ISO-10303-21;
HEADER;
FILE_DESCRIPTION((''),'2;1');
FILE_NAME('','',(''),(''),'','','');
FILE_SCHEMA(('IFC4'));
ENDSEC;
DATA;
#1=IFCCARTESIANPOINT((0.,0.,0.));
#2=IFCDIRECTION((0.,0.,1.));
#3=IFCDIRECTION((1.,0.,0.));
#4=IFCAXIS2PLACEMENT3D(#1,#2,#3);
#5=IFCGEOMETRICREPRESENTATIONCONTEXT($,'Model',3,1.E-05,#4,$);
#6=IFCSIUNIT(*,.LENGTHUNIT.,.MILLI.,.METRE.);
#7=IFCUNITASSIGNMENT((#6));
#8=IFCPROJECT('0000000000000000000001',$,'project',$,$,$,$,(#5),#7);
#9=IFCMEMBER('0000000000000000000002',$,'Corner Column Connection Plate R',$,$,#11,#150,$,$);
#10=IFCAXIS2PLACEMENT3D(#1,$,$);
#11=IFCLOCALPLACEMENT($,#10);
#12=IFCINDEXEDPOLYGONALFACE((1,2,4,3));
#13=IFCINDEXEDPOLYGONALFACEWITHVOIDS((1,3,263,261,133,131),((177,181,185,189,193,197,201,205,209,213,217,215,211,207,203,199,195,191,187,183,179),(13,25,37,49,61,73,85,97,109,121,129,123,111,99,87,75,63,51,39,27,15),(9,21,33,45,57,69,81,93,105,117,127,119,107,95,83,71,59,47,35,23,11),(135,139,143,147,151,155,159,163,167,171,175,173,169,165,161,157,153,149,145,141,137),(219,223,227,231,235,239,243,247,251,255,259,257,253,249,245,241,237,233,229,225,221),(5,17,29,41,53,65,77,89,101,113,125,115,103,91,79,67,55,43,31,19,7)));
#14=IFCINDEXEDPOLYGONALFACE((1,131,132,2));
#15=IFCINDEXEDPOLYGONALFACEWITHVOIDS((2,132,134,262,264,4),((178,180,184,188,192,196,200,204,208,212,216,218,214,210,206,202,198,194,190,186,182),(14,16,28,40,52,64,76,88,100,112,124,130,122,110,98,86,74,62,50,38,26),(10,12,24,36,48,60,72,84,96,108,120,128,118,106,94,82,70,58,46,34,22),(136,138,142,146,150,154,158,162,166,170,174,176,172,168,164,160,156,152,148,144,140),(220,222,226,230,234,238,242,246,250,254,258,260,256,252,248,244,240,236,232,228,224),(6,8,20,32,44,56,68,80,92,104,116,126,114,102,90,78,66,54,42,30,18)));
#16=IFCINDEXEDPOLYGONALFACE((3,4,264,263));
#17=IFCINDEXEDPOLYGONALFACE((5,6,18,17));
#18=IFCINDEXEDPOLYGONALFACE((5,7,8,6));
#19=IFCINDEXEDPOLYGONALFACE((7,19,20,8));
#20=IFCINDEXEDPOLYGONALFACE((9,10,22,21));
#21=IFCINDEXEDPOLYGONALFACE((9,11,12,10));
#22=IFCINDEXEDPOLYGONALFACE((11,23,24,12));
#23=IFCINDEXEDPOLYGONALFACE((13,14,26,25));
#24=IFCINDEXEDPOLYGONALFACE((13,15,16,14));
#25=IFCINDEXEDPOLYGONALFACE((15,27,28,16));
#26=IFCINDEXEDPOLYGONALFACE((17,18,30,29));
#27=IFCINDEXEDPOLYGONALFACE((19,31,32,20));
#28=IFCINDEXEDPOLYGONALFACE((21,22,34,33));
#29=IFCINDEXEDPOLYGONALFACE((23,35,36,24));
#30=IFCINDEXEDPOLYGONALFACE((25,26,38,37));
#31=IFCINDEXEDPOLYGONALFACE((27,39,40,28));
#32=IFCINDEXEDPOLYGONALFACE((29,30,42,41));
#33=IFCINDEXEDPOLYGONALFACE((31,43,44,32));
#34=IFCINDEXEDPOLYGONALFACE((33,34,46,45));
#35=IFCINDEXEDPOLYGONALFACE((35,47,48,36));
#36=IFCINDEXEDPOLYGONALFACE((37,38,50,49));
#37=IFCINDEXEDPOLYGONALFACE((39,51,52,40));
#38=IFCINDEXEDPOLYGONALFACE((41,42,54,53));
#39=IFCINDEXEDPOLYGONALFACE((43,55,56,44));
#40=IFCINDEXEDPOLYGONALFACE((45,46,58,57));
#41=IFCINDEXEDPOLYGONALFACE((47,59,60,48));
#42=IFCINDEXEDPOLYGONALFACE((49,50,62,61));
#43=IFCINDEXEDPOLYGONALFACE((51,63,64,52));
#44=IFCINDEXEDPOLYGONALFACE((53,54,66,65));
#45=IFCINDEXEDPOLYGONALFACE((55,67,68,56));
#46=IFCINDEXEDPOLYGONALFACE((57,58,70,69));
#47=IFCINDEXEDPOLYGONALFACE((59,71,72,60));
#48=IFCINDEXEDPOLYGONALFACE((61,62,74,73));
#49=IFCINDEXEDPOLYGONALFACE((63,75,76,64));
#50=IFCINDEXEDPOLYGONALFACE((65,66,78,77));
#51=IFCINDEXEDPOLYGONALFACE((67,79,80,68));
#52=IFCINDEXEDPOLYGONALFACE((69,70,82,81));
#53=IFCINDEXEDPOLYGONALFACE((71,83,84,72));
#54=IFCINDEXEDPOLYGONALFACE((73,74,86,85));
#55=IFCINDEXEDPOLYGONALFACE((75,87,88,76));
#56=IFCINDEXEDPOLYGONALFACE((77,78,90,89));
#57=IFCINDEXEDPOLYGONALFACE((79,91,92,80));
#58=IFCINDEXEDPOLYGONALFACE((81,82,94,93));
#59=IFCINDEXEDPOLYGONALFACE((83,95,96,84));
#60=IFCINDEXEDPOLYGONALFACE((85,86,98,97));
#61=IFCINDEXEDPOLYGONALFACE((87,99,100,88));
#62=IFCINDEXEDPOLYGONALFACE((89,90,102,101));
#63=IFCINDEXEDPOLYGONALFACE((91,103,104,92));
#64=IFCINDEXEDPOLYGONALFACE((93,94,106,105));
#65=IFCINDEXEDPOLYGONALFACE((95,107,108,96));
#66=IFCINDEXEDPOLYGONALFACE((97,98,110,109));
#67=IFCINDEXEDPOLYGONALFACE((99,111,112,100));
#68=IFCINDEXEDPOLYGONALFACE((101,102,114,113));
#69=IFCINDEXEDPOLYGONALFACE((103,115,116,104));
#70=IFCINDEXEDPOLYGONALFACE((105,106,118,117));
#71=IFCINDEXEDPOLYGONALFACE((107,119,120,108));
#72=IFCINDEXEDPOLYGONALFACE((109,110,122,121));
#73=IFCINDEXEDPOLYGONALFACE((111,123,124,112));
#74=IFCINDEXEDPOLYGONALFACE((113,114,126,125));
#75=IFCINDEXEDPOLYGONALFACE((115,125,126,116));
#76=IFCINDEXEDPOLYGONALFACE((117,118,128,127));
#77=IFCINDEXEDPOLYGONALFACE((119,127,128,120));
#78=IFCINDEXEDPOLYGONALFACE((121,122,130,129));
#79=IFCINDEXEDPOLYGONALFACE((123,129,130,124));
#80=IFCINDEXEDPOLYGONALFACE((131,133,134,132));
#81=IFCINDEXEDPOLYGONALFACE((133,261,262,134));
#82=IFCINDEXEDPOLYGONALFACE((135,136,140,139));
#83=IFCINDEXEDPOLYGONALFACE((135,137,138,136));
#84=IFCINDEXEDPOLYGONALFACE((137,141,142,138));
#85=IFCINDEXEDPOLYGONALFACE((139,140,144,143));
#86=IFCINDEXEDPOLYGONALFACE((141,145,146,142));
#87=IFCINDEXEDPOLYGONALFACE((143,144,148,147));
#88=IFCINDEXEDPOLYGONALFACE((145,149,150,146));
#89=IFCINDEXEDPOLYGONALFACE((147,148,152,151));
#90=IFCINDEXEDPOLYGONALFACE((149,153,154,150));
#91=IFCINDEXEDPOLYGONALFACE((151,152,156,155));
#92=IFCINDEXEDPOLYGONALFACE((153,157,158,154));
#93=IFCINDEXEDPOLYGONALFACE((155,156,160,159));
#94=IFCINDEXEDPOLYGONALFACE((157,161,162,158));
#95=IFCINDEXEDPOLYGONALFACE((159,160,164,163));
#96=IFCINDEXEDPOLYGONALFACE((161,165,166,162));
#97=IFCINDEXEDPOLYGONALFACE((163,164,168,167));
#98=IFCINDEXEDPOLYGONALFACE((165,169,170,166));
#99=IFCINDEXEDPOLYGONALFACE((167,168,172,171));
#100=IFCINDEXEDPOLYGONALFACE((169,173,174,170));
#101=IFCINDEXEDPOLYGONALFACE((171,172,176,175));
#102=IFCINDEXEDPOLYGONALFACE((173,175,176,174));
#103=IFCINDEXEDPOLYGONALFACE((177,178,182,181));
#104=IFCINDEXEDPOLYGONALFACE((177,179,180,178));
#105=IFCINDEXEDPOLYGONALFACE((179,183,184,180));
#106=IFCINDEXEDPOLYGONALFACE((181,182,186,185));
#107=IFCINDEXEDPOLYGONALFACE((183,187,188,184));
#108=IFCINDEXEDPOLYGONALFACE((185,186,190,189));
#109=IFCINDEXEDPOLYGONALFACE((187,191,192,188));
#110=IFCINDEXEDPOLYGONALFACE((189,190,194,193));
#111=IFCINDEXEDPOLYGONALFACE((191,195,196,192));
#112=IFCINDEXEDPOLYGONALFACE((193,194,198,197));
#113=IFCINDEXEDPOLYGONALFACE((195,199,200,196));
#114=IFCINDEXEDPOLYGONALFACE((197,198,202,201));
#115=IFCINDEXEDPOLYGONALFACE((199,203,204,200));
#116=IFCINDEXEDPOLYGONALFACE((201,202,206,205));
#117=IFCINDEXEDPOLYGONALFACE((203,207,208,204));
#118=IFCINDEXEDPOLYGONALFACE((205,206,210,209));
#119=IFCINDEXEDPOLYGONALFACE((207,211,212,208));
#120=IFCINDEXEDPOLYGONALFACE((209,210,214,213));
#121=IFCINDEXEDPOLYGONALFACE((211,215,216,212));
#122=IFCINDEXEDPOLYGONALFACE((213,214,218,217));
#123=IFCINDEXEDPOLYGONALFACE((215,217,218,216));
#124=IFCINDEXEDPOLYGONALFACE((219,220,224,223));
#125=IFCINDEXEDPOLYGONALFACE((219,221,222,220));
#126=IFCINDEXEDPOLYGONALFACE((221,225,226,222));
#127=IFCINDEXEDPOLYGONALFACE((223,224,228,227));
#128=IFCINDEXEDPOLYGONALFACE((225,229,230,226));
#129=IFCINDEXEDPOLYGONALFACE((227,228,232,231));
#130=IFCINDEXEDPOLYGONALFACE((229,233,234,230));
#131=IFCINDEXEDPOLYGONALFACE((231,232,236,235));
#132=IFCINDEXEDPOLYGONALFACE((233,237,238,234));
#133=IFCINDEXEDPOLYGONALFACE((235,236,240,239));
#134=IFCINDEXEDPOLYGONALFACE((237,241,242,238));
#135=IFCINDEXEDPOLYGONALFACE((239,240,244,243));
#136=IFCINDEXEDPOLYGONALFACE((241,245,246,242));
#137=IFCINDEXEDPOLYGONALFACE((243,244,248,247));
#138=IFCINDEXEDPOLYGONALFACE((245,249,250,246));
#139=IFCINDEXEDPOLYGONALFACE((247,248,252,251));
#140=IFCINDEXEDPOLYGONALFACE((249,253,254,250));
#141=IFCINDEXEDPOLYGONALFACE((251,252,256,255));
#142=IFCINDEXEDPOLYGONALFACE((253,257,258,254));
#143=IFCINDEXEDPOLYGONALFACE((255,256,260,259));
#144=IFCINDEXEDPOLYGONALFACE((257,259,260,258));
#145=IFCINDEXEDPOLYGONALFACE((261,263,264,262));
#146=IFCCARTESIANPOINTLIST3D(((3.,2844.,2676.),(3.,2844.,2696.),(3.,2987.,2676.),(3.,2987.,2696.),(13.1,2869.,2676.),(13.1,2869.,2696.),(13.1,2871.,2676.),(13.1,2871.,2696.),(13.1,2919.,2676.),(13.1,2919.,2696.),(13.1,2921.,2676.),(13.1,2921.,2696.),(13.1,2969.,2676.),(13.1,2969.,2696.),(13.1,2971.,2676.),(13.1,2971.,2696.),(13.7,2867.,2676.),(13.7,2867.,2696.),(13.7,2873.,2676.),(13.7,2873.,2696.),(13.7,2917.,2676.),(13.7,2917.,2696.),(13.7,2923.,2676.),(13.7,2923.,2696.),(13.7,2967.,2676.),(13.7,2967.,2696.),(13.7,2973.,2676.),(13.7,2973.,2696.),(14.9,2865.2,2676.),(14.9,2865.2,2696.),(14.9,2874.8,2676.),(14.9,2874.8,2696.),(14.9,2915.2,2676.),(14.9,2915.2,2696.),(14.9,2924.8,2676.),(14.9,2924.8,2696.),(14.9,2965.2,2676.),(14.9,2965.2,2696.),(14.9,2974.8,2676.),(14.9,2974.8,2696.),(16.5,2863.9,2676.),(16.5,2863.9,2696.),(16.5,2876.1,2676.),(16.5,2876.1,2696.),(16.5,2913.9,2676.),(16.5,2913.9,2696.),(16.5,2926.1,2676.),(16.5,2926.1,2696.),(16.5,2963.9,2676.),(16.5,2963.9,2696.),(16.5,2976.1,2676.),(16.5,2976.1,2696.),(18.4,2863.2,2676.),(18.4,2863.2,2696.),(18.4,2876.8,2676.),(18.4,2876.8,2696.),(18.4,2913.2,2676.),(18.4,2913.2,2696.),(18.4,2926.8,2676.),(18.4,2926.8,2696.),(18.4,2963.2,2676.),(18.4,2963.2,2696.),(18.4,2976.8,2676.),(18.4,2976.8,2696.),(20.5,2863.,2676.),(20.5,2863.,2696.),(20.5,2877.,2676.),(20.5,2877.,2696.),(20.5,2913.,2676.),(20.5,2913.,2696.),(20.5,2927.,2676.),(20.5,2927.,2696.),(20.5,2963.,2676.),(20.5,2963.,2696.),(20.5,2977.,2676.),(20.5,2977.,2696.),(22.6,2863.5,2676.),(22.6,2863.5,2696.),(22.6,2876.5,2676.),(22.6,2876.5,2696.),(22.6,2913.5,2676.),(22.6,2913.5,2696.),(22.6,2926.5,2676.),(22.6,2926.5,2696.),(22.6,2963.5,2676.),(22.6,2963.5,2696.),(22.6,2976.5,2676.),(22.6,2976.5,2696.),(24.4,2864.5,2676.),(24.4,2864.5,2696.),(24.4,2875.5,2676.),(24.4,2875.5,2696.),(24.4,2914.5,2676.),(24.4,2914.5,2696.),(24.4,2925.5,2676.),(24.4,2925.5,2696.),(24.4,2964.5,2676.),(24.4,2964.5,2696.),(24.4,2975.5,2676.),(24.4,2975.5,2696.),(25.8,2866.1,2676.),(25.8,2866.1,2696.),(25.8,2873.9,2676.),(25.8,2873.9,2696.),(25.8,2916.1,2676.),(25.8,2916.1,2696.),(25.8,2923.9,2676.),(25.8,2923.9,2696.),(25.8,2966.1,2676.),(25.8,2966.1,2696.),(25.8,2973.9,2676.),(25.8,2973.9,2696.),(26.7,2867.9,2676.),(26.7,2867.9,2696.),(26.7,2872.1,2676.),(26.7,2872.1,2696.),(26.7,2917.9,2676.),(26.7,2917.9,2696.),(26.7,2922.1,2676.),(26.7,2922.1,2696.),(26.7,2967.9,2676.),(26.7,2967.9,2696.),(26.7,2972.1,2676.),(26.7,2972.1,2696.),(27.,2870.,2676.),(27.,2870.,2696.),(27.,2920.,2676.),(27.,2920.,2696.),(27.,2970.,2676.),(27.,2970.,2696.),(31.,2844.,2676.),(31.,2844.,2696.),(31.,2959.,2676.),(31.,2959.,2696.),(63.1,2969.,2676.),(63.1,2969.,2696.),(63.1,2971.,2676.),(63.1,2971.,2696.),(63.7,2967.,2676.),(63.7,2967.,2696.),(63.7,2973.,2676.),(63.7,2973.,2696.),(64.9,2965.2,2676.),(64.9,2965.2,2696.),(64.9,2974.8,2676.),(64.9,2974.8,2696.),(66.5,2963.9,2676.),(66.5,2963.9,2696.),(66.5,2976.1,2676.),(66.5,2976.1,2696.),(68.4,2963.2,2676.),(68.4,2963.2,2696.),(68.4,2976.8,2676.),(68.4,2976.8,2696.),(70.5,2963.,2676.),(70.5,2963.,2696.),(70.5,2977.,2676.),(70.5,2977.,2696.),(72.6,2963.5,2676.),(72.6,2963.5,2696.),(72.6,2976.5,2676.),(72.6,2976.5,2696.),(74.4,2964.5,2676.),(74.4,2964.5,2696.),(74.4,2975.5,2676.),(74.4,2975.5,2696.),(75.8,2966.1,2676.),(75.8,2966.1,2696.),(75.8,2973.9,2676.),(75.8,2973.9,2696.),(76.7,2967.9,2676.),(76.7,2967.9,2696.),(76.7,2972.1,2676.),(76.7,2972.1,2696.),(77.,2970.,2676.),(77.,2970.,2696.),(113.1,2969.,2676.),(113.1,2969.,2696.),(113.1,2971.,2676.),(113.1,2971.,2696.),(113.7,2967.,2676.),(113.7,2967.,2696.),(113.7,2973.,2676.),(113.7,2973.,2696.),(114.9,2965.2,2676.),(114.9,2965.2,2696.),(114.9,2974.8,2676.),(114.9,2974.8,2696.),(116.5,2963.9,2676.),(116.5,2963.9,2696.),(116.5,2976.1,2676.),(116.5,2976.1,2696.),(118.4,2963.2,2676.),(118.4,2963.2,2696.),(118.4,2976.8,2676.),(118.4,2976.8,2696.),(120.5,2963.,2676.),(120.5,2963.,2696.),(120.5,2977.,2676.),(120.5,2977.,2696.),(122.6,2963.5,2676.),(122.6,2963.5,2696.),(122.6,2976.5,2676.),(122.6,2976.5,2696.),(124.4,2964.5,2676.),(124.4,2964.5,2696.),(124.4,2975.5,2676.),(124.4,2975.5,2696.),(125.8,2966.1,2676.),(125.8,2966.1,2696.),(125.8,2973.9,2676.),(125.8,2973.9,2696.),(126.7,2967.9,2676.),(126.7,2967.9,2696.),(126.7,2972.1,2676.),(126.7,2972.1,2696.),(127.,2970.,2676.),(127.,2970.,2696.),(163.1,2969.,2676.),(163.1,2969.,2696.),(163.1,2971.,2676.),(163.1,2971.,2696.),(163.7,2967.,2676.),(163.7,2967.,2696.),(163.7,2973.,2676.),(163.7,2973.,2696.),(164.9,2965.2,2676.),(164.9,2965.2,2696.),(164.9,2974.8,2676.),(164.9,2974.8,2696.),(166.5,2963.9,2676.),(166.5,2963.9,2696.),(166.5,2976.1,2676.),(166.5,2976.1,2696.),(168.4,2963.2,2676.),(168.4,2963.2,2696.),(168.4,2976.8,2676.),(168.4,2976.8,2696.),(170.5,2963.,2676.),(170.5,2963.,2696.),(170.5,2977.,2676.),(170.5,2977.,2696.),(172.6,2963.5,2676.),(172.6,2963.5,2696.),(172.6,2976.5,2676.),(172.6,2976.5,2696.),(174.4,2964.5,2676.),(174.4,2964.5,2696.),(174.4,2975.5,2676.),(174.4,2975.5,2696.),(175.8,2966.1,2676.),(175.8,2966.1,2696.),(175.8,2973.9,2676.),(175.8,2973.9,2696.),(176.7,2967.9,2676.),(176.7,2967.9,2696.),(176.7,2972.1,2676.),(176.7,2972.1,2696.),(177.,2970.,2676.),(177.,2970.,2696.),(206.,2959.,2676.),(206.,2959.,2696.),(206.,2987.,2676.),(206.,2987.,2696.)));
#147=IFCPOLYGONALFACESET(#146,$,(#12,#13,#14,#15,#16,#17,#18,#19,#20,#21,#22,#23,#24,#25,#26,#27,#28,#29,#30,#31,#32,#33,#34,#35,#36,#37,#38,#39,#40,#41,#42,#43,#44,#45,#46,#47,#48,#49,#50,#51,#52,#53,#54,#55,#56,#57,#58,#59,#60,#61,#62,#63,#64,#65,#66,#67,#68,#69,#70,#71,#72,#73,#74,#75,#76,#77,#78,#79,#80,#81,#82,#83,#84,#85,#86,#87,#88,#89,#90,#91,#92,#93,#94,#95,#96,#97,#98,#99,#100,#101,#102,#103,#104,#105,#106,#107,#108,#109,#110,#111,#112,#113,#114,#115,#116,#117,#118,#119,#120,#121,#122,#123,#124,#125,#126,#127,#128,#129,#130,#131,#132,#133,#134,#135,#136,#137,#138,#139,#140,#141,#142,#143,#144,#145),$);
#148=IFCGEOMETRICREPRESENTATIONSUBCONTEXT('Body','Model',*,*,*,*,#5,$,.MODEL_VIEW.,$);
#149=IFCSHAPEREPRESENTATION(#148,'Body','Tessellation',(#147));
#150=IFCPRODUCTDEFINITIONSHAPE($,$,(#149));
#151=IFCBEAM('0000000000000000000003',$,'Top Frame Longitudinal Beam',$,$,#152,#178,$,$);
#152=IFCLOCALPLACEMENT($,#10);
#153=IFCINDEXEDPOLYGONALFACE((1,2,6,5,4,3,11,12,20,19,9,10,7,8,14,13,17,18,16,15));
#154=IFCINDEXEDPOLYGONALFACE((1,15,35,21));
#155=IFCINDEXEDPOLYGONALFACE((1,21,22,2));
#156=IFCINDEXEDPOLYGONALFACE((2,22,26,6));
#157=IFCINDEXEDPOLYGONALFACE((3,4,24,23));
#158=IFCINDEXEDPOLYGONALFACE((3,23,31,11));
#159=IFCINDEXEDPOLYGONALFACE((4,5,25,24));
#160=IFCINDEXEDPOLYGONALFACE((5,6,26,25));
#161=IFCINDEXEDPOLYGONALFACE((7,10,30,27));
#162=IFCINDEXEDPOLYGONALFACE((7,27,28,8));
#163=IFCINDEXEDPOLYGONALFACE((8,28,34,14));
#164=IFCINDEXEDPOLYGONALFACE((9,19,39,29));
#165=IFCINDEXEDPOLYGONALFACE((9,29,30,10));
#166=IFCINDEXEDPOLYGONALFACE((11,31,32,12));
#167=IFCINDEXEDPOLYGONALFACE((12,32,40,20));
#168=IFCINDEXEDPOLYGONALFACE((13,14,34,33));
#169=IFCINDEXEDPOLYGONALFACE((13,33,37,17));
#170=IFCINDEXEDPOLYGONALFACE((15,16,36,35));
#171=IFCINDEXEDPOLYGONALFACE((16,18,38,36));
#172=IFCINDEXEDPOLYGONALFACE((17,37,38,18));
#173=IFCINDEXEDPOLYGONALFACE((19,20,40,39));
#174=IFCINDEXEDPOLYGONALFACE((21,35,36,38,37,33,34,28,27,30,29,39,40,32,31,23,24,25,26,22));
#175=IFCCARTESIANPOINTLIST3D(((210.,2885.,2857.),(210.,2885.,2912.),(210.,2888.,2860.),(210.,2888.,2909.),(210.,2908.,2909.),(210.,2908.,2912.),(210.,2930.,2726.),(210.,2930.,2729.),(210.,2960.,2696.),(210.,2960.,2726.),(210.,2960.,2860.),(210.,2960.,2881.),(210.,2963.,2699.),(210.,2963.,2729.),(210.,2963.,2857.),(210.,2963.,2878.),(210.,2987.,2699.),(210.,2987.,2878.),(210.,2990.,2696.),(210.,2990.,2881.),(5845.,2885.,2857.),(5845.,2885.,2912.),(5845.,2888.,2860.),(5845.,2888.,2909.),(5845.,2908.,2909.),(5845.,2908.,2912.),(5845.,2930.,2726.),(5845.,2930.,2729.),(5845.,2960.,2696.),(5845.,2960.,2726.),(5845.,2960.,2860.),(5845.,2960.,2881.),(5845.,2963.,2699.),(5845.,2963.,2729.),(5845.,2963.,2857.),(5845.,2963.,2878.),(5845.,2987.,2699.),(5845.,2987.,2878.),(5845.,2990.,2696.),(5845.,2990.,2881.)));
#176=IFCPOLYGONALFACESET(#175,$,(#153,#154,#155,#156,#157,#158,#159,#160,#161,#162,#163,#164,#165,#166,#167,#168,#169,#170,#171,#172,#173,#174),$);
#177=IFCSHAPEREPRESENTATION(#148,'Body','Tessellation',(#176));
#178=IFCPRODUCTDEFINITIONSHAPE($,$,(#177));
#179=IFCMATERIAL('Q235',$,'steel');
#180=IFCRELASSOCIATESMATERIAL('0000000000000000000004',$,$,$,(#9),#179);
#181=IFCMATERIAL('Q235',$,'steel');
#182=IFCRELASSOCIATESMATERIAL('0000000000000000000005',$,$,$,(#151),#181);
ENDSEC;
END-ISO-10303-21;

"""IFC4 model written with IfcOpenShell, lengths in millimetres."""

from ifc_helpers import new_model, si_unit, frame, origin_with_axes, origin_2d, place, context, subcontext, project, line, indexed_curve, circle_curve, outline, extrude, material, element, save


model = new_model("IFC4")

# Units and contexts
model_context = context("Model", 3, precision=1e-05, world=origin_with_axes())
body_context = subcontext(model_context, "Body", "Model", "MODEL_VIEW")
ifc_project = project(units=[si_unit("LENGTHUNIT", "METRE", prefix="MILLI")], contexts=[model_context])

# Member, openings
ifc_material_1 = material(Name="Q235", Category="steel")
member_1_placement = place(None, frame((3.0, 2987.0, 2676.0), z_axis=(0.0, 0.0, 1.0), x_axis=(1.0, 0.0, 0.0)))
member_1 = element("IfcMember", 1, at=member_1_placement, material=ifc_material_1, Name="Corner Column Connection Plate R", context=body_context, shape_type="SweptSolid", body=[
    extrude(outline(indexed_curve([(0.0, 0.0), (203.0, 0.0), (203.0, -28.0), (28.0, -28.0), (28.0, -143.0), (0.0, -143.0), (0.0, 0.0)], segments=[line(1, 2, 3, 4, 5, 6, 7, 1)])), origin_with_axes(), (0.0, 0.0, 1.0), 20.0),
])
opening_1_placement = place(member_1_placement, frame((17.0, -17.0, 0.0), z_axis=(0.0, 0.0, 1.0), x_axis=(1.0, 0.0, 0.0)))
element("IfcOpeningElement", 2, at=opening_1_placement, cuts=member_1, context=body_context, shape_type="SweptSolid", body=[
    extrude(outline(circle_curve(origin_2d(), 7.0)), origin_with_axes(), (0.0, 0.0, 1.0), 20.0),
])
opening_2_placement = place(member_1_placement, frame((67.0, -17.0, 0.0), z_axis=(0.0, 0.0, 1.0), x_axis=(1.0, 0.0, 0.0)))
element("IfcOpeningElement", 3, at=opening_2_placement, cuts=member_1, context=body_context, shape_type="SweptSolid", body=[
    extrude(outline(circle_curve(origin_2d(), 7.0)), origin_with_axes(), (0.0, 0.0, 1.0), 20.0),
])
opening_3_placement = place(member_1_placement, frame((117.0, -17.0, 0.0), z_axis=(0.0, 0.0, 1.0), x_axis=(1.0, 0.0, 0.0)))
element("IfcOpeningElement", 4, at=opening_3_placement, cuts=member_1, context=body_context, shape_type="SweptSolid", body=[
    extrude(outline(circle_curve(origin_2d(), 7.0)), origin_with_axes(), (0.0, 0.0, 1.0), 20.0),
])
opening_4_placement = place(member_1_placement, frame((167.0, -17.0, 0.0), z_axis=(0.0, 0.0, 1.0), x_axis=(1.0, 0.0, 0.0)))
element("IfcOpeningElement", 5, at=opening_4_placement, cuts=member_1, context=body_context, shape_type="SweptSolid", body=[
    extrude(outline(circle_curve(origin_2d(), 7.0)), origin_with_axes(), (0.0, 0.0, 1.0), 20.0),
])
opening_5_placement = place(member_1_placement, frame((17.0, -67.0, 0.0), z_axis=(0.0, 0.0, 1.0), x_axis=(1.0, 0.0, 0.0)))
element("IfcOpeningElement", 6, at=opening_5_placement, cuts=member_1, context=body_context, shape_type="SweptSolid", body=[
    extrude(outline(circle_curve(origin_2d(), 7.0)), origin_with_axes(), (0.0, 0.0, 1.0), 20.0),
])
opening_6_placement = place(member_1_placement, frame((17.0, -117.0, 0.0), z_axis=(0.0, 0.0, 1.0), x_axis=(1.0, 0.0, 0.0)))
element("IfcOpeningElement", 7, at=opening_6_placement, cuts=member_1, context=body_context, shape_type="SweptSolid", body=[
    extrude(outline(circle_curve(origin_2d(), 7.0)), origin_with_axes(), (0.0, 0.0, 1.0), 20.0),
])

# Beam
ifc_material_2 = material(Name="Q235", Category="steel")
beam_1_placement = place(None, frame((210.0, 2990.0, 2696.0), z_axis=(1.0, 0.0, 0.0), x_axis=(0.0, -1.0, 0.0)))
element("IfcBeam", 8, at=beam_1_placement, material=ifc_material_2, Name="Top Frame Longitudinal Beam", context=body_context, shape_type="SweptSolid", body=[
    extrude(outline(indexed_curve([(60.0, -30.0), (30.0, -30.0), (30.0, 0.0), (0.0, 0.0), (0.0, -185.0), (30.0, -185.0), (30.0, -164.0), (102.0, -164.0), (102.0, -213.0), (82.0, -213.0), (82.0, -216.0), (105.0, -216.0), (105.0, -161.0), (27.0, -161.0), (27.0, -182.0), (3.0, -182.0), (3.0, -3.0), (27.0, -3.0), (27.0, -33.0), (60.0, -33.0), (60.0, -30.0)], segments=[line(1, 2, 3, 4, 5, 6, 7, 8, 9, 10, 11, 12, 13, 14, 15, 16, 17, 18, 19, 20, 21, 1)])), origin_with_axes(), (0.0, 0.0, 1.0), 5635.0),
])

save(model, "model.ifc")
